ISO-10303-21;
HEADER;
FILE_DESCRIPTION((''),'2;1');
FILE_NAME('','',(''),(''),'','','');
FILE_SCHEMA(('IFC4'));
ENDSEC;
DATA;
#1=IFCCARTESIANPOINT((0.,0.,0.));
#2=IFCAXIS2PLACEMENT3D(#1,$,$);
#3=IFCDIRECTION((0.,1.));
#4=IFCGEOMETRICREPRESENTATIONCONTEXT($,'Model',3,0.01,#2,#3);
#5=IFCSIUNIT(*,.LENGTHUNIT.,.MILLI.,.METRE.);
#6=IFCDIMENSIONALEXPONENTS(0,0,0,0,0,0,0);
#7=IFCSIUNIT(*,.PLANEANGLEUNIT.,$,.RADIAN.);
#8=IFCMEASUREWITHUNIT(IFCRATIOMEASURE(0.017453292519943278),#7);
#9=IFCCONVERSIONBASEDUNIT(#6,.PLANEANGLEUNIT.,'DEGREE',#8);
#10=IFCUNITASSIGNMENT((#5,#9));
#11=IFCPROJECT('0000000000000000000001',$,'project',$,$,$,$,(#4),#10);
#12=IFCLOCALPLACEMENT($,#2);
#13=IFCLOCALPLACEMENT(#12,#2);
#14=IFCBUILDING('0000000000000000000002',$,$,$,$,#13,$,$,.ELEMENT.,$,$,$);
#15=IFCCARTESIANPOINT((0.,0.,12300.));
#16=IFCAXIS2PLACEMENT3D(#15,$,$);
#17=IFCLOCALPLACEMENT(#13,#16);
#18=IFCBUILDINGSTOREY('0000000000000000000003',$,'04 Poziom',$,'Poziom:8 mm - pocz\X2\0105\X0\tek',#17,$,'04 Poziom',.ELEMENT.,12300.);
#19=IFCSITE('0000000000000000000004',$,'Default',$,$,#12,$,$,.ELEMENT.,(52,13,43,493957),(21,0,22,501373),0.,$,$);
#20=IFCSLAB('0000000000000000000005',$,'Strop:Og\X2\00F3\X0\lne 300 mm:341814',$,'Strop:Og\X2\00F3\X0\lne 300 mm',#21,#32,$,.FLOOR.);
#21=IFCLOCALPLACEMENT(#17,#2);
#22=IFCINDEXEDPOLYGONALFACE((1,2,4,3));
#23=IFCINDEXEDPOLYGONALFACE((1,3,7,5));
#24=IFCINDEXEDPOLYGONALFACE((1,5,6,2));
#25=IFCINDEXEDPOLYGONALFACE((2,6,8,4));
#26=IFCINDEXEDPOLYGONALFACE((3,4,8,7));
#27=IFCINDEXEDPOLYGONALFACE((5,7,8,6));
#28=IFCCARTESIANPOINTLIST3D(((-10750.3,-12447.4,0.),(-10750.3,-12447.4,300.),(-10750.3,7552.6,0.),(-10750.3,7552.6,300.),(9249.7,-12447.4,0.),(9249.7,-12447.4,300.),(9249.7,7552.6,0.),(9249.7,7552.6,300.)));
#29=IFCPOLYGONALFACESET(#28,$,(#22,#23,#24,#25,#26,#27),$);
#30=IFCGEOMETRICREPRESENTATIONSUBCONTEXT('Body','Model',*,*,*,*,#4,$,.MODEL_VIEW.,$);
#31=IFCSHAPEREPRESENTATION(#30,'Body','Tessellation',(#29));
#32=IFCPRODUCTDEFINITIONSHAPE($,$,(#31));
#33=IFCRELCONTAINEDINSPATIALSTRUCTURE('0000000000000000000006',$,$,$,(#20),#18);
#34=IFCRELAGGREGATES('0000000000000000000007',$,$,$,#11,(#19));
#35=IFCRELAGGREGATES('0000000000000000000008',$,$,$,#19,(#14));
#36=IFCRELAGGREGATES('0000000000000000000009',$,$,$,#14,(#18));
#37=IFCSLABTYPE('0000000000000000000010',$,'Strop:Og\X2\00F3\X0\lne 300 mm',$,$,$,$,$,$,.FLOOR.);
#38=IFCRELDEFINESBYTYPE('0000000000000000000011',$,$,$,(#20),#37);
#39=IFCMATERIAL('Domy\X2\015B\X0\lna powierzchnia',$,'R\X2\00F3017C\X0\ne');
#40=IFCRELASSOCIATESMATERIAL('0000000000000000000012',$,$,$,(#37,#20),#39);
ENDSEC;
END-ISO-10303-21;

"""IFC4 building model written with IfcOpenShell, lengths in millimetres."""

from ifc_helpers import new_model, entity, si_unit, converted_unit, direction, frame, origin, place, context, subcontext, project, spatial, indexed_curve, outline, extrude, material, type_object, element, save


model = new_model("IFC4")

# Units and contexts
model_context = context("Model", 3, precision=0.01, world=origin(), true_north=direction((0.0, 1.0)))
body_context = subcontext(model_context, "Body", "Model", "MODEL_VIEW")
ifc_project = project(units=[si_unit("LENGTHUNIT", "METRE", prefix="MILLI"), converted_unit("PLANEANGLEUNIT", "DEGREE", entity("IfcRatioMeasure", 0.017453292519943278), si_unit("PLANEANGLEUNIT", "RADIAN"), dimensions=[0, 0, 0, 0, 0, 0, 0])], contexts=[model_context])

# Site, building, storey
site_placement = place(None, origin())
site = spatial("IfcSite", under=ifc_project, at=site_placement, Name="Default", CompositionType="ELEMENT", RefLatitude=(52, 13, 43, 493957), RefLongitude=(21, 0, 22, 501373), RefElevation=0.0)
building_placement = place(site_placement, origin())
building = spatial("IfcBuilding", under=site, at=building_placement, CompositionType="ELEMENT")
storey_placement = place(building_placement, frame((0.0, 0.0, 12300.0)))
storey = spatial("IfcBuildingStorey", under=building, at=storey_placement, Name="04 Poziom", ObjectType="Poziom:8 mm - początek", LongName="04 Poziom", CompositionType="ELEMENT", Elevation=12300.0)

# Slab
ifc_material_1 = material(Name="Domyślna powierzchnia", Category="Różne")
slab_type = type_object("IfcSlabType", Name="Strop:Ogólne 300 mm", PredefinedType="FLOOR", material=ifc_material_1)
slab_placement = place(storey_placement, origin())
element("IfcSlab", 1, at=slab_placement, inside=storey, type_object=slab_type, material=ifc_material_1, Name="Strop:Ogólne 300 mm:341814", ObjectType="Strop:Ogólne 300 mm", PredefinedType="FLOOR", context=body_context, shape_type="SweptSolid", body=[
    extrude(outline(indexed_curve([(-10000.0, -10000.0), (10000.0, -10000.0), (10000.0, 10000.0), (-10000.0, 10000.0), (-10000.0, -10000.0)], self_intersect=False)), frame((-750.3, -2447.4, 300.0), z_axis=(0.0, 0.0, -1.0), x_axis=(0.0, 1.0, 0.0)), (0.0, 0.0, 1.0), 300.0),
])

save(model, "model.ifc")
